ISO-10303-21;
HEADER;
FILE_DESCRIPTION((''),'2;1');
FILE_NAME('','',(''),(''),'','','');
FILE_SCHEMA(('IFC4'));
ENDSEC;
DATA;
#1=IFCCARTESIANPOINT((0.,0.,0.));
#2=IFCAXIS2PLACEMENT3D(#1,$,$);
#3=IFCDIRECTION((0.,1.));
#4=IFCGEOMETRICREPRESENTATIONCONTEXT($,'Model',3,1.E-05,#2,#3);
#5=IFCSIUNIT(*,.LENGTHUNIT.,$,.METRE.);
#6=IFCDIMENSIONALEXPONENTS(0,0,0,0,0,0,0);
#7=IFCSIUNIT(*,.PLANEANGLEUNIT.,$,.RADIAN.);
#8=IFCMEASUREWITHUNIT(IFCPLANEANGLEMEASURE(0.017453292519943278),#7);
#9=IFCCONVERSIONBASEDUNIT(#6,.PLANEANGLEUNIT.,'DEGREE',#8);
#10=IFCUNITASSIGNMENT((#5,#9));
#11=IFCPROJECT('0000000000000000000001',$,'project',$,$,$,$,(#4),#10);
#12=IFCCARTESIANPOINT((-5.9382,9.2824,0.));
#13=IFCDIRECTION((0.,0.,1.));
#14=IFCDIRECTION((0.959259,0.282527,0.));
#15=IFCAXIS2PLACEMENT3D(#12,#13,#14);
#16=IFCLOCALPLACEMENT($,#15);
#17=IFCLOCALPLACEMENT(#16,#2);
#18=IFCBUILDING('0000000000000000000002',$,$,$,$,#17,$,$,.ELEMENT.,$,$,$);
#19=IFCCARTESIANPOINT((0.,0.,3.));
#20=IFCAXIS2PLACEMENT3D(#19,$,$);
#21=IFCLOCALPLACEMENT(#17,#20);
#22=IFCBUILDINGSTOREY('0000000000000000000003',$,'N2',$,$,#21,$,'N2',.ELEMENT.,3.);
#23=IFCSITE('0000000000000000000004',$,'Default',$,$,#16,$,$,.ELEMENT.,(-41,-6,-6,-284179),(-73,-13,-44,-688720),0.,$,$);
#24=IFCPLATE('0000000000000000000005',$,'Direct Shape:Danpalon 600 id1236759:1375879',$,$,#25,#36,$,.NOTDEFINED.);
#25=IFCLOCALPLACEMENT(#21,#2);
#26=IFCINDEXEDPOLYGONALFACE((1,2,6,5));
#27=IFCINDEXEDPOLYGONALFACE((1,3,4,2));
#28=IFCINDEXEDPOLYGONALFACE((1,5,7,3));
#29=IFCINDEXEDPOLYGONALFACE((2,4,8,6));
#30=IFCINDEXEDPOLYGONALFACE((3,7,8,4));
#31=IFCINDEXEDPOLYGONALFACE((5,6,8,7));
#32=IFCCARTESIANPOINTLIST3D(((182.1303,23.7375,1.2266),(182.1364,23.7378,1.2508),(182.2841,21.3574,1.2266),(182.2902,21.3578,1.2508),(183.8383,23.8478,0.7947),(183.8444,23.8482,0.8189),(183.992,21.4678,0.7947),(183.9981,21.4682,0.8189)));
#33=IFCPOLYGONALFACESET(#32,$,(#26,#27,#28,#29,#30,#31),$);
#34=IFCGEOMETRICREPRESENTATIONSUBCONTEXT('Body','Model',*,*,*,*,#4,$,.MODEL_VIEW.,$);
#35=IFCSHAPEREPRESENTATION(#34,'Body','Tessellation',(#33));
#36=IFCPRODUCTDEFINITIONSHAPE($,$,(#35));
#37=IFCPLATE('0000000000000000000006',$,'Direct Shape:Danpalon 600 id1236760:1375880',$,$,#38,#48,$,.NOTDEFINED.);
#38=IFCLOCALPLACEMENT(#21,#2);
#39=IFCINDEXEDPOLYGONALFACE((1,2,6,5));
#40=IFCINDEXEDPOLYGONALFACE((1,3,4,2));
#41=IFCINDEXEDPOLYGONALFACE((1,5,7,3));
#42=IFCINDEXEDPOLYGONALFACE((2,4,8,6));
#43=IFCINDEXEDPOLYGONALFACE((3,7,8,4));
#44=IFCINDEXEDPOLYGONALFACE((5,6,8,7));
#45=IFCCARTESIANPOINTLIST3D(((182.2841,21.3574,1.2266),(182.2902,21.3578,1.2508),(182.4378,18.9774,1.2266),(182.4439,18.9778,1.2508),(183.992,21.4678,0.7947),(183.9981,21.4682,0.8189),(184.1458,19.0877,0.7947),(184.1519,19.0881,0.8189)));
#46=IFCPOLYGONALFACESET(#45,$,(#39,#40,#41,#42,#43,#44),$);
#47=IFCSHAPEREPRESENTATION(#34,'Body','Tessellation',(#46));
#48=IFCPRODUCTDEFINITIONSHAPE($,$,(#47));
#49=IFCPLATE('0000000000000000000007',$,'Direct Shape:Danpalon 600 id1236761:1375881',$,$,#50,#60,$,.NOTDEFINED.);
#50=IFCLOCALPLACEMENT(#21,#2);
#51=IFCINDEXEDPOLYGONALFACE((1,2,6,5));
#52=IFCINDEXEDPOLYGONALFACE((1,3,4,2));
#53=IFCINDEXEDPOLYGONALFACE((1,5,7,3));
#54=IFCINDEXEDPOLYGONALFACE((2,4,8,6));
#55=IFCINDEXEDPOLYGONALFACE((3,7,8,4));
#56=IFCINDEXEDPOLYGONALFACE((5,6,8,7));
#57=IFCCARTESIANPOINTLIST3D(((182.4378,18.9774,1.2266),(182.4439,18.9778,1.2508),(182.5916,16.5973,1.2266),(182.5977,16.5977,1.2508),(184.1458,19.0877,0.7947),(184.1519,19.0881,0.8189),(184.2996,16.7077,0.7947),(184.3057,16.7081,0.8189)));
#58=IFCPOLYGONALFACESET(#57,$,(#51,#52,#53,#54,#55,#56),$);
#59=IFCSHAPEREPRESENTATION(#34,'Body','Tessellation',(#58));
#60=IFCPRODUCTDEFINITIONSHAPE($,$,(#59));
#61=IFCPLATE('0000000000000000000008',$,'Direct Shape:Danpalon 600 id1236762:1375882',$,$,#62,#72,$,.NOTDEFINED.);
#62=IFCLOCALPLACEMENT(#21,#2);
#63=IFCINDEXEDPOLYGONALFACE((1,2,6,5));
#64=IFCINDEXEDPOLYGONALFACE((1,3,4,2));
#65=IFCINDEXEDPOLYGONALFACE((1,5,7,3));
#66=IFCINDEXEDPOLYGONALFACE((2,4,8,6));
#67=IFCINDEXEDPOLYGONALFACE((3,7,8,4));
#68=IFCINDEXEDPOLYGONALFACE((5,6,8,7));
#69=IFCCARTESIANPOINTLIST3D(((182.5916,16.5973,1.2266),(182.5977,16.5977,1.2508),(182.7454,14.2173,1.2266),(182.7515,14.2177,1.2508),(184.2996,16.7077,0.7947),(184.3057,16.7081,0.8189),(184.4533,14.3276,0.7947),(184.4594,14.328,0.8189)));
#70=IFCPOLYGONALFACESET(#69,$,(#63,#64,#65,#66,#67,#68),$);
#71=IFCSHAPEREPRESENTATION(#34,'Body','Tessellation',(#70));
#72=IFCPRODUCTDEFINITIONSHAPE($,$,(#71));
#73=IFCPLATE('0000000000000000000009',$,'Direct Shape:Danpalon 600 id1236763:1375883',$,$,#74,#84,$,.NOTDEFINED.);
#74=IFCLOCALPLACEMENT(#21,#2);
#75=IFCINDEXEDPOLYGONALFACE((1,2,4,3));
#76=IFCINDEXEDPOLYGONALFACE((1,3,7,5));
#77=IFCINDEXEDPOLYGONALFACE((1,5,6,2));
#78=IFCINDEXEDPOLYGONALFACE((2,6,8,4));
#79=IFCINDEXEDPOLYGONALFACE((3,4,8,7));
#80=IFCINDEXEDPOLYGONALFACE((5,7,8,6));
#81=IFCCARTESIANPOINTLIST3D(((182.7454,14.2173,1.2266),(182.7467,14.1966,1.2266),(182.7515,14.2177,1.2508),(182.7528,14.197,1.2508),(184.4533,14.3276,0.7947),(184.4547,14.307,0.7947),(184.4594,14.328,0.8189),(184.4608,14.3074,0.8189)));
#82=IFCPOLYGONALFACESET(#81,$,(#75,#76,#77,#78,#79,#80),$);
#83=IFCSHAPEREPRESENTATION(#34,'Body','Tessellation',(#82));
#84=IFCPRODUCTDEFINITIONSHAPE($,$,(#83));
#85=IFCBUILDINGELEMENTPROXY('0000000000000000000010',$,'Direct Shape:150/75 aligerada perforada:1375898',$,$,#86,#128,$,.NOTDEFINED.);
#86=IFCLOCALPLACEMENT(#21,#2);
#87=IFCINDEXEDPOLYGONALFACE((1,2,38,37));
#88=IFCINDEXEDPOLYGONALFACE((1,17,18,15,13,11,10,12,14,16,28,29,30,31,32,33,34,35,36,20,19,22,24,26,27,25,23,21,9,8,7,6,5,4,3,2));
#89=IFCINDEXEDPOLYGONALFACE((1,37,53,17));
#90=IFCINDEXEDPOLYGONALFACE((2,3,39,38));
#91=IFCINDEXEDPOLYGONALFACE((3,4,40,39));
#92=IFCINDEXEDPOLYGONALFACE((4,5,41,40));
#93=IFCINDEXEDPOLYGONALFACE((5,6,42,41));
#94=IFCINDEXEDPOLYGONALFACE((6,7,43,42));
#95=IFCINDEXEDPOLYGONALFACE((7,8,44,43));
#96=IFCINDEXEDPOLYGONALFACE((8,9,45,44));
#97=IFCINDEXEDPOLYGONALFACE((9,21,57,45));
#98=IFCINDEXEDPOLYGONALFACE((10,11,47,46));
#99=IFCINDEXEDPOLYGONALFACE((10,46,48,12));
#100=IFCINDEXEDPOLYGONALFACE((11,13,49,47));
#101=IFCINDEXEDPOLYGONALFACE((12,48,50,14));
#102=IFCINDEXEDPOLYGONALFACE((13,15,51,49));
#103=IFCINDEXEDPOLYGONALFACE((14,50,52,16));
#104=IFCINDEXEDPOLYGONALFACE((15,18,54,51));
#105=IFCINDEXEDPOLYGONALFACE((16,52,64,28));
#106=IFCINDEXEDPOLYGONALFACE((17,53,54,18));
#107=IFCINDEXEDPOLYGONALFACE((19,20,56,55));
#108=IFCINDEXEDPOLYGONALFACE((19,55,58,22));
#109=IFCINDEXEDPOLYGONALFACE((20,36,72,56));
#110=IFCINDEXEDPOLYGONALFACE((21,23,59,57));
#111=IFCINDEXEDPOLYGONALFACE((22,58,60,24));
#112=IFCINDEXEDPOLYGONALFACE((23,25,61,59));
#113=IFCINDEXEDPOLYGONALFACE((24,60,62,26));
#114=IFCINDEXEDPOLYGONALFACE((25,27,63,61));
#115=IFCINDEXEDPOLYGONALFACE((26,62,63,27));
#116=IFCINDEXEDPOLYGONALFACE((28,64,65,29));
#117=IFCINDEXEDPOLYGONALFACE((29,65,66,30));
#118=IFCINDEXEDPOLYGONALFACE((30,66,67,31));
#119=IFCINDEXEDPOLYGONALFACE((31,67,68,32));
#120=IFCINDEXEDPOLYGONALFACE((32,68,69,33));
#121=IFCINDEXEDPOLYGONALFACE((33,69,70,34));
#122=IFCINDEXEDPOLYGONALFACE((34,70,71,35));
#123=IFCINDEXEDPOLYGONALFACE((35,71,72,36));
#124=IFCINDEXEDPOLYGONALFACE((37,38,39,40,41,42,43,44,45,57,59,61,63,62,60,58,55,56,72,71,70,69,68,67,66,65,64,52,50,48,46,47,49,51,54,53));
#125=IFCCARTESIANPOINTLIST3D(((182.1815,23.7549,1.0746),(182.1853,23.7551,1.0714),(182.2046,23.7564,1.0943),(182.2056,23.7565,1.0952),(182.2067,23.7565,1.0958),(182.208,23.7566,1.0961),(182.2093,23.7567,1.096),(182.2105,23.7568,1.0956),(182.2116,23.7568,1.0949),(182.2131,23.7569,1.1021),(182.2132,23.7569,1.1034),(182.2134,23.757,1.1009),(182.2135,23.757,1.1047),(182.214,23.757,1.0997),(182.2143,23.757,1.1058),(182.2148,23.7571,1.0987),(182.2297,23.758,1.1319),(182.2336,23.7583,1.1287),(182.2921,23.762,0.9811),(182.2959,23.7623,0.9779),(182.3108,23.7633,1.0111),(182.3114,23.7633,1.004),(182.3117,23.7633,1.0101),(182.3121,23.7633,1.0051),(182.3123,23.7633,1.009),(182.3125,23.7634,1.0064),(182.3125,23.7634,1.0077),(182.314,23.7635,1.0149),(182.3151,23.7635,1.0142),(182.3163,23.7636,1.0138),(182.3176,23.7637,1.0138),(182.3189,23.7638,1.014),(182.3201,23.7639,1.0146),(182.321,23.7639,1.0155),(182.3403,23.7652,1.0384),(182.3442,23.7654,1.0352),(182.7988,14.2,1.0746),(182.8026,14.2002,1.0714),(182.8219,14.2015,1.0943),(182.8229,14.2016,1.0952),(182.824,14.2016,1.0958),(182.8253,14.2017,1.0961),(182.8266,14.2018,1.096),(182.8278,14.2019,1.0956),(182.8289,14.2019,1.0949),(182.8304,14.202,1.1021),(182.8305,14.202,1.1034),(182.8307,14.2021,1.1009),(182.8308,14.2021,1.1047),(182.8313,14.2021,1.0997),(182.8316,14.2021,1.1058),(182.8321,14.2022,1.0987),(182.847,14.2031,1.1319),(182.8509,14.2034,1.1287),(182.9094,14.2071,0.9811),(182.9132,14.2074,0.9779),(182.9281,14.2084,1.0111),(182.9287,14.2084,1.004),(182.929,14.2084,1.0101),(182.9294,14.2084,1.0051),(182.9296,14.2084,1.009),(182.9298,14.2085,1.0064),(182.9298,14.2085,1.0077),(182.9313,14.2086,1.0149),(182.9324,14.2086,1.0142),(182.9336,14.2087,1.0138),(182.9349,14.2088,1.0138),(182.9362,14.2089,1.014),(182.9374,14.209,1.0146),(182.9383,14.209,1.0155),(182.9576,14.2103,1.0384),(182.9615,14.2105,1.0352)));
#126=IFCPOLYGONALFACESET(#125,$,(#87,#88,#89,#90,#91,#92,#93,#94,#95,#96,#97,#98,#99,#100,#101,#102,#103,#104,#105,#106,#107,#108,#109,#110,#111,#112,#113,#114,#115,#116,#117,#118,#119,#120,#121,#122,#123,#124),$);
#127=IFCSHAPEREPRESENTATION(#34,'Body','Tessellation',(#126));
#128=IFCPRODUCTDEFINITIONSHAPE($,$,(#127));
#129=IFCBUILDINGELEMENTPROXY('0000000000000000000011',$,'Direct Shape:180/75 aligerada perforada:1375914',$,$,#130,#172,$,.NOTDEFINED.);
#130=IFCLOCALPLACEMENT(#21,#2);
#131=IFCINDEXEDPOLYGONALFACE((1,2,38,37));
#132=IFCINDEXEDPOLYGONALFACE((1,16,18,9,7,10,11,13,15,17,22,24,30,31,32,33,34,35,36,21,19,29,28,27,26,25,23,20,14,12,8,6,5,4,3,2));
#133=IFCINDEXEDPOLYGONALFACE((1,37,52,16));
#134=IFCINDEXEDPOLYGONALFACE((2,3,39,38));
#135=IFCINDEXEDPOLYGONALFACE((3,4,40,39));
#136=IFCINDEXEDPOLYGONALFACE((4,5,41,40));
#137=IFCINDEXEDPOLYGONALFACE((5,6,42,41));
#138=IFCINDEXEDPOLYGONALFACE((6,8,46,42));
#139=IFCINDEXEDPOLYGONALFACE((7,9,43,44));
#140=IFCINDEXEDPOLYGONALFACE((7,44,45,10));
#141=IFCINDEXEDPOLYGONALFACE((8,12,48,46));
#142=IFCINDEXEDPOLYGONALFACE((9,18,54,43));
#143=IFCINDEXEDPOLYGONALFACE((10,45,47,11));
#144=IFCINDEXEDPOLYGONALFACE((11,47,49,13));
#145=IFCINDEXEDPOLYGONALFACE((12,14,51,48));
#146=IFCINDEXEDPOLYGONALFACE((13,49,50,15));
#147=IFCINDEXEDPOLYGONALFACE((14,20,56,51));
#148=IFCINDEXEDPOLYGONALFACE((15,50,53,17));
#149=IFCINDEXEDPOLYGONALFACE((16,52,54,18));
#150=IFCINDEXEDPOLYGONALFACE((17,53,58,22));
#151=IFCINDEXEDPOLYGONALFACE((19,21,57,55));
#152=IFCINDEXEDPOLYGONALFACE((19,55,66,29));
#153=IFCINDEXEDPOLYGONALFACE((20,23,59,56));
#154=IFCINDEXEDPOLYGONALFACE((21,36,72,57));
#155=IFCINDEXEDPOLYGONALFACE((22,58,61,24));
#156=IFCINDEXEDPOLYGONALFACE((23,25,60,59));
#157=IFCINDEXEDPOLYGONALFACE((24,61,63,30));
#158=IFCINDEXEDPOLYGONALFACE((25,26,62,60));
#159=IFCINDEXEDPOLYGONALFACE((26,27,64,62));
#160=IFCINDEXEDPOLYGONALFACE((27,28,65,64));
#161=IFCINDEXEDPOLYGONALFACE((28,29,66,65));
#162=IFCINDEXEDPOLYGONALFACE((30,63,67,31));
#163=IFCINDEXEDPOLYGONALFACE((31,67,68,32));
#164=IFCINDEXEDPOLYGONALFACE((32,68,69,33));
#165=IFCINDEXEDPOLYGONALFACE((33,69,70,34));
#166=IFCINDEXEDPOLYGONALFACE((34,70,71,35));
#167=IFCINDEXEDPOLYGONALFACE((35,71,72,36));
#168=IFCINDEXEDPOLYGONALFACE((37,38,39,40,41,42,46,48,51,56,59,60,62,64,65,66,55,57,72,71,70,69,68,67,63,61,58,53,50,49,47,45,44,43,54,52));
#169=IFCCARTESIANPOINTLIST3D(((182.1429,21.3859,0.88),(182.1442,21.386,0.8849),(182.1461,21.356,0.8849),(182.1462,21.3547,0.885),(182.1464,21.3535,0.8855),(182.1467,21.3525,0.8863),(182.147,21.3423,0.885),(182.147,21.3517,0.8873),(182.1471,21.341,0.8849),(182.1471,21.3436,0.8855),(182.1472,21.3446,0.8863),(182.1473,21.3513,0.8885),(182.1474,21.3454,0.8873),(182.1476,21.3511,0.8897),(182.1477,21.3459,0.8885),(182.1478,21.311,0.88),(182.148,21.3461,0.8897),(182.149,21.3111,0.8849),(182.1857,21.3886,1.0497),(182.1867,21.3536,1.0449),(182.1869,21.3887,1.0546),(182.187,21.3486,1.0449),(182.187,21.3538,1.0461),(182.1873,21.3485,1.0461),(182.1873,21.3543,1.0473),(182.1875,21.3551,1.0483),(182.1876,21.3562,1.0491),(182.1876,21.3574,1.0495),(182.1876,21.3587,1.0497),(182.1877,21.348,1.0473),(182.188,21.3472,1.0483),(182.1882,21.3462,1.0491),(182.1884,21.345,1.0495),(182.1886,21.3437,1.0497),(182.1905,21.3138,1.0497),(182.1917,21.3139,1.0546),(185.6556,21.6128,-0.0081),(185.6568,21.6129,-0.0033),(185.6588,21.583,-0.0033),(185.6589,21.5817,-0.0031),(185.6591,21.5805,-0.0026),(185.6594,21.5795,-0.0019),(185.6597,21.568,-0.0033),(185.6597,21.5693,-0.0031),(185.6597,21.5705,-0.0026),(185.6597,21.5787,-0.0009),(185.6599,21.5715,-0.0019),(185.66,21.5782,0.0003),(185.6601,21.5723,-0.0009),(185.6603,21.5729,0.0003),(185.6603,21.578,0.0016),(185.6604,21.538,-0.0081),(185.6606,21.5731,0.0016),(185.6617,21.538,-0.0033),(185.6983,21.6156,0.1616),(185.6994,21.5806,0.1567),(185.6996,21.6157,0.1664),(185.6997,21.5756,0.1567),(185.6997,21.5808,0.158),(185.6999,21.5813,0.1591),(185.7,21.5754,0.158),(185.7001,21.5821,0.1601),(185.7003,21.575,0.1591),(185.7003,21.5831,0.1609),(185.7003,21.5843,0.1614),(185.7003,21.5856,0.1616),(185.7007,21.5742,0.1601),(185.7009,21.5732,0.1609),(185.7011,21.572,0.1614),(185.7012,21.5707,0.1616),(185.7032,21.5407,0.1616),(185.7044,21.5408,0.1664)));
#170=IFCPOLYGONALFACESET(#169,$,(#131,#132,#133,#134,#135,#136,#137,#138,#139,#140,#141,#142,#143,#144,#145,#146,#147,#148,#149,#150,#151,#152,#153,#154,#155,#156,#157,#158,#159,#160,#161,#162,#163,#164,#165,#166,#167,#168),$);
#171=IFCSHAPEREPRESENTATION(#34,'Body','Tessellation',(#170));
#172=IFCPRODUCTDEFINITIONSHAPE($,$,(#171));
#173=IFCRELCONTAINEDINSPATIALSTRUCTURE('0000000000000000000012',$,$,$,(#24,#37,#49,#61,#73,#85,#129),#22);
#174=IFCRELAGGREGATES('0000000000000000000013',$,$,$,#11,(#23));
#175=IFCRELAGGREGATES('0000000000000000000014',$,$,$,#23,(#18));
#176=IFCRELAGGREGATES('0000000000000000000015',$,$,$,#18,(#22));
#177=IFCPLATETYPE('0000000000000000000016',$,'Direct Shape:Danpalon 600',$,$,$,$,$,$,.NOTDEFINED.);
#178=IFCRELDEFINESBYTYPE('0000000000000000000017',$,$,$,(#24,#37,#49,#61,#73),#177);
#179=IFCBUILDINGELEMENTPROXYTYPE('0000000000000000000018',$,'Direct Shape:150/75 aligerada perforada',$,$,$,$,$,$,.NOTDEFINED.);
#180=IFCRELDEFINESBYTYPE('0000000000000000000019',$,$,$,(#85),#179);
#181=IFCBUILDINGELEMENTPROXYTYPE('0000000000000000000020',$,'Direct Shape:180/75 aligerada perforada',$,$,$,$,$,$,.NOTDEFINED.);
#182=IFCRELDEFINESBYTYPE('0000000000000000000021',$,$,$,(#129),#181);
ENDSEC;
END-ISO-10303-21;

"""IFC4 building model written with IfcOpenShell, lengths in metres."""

from ifc_helpers import new_model, entity, si_unit, converted_unit, direction, frame, frame_2d, origin, origin_2d_with_axis, place, context, subcontext, project, spatial, polyline, circle_curve, parameter, trimmed, segment, composite_curve, rectangle, outline, extrude, type_object, element, save


model = new_model("IFC4")

# Units and contexts
model_context = context("Model", 3, precision=1e-05, world=origin(), true_north=direction((0.0, 1.0)))
body_context = subcontext(model_context, "Body", "Model", "MODEL_VIEW")
ifc_project = project(units=[si_unit("LENGTHUNIT", "METRE"), converted_unit("PLANEANGLEUNIT", "DEGREE", entity("IfcPlaneAngleMeasure", 0.017453292519943278), si_unit("PLANEANGLEUNIT", "RADIAN"), dimensions=[0, 0, 0, 0, 0, 0, 0])], contexts=[model_context])

# Site, building, storey
site_placement = place(None, frame((-5.9382, 9.2824, 0.0), z_axis=(0.0, 0.0, 1.0), x_axis=(0.959259, 0.282527, 0.0)))
site = spatial("IfcSite", under=ifc_project, at=site_placement, Name="Default", CompositionType="ELEMENT", RefLatitude=(-41, -6, -6, -284179), RefLongitude=(-73, -13, -44, -688720), RefElevation=0.0)
building_placement = place(site_placement, origin())
building = spatial("IfcBuilding", under=site, at=building_placement, CompositionType="ELEMENT")
storey_placement = place(building_placement, frame((0.0, 0.0, 3.0)))
storey = spatial("IfcBuildingStorey", under=building, at=storey_placement, Name="N2", LongName="N2", CompositionType="ELEMENT", Elevation=3.0)

# Plates
plate_type = type_object("IfcPlateType", Name="Direct Shape:Danpalon 600", PredefinedType="NOTDEFINED")
plate_1_placement = place(storey_placement, origin())
element("IfcPlate", 1, at=plate_1_placement, inside=storey, type_object=plate_type, Name="Direct Shape:Danpalon 600 id1236759:1375879", PredefinedType="NOTDEFINED", context=body_context, shape_type="SweptSolid", body=[
    extrude(rectangle(XDim=0.025, YDim=1.7652, at=frame_2d((0.0, 0.0), x_axis=(1.0, 0.0))), frame((183.1411, 21.4128, 1.0228), z_axis=(-0.064471, 0.99792, 0.0), x_axis=(0.24414, 0.015773, 0.969612)), (0.0, 0.0, 1.0), 2.385),
])
plate_2_placement = place(storey_placement, origin())
element("IfcPlate", 2, at=plate_2_placement, inside=storey, type_object=plate_type, Name="Direct Shape:Danpalon 600 id1236760:1375880", PredefinedType="NOTDEFINED", context=body_context, shape_type="SweptSolid", body=[
    extrude(rectangle(XDim=0.025, YDim=1.7652, at=frame_2d((0.0, 0.0), x_axis=(1.0, 0.0))), frame((183.2949, 19.0327, 1.0228), z_axis=(-0.064471, 0.99792, 0.0), x_axis=(0.24414, 0.015773, 0.969612)), (0.0, 0.0, 1.0), 2.385),
])
plate_3_placement = place(storey_placement, origin())
element("IfcPlate", 3, at=plate_3_placement, inside=storey, type_object=plate_type, Name="Direct Shape:Danpalon 600 id1236761:1375881", PredefinedType="NOTDEFINED", context=body_context, shape_type="SweptSolid", body=[
    extrude(rectangle(XDim=0.025, YDim=1.7652, at=frame_2d((0.0, 0.0), x_axis=(1.0, 0.0))), frame((183.4486, 16.6527, 1.0228), z_axis=(-0.064471, 0.99792, 0.0), x_axis=(0.24414, 0.015773, 0.969612)), (0.0, 0.0, 1.0), 2.385),
])
plate_4_placement = place(storey_placement, origin())
element("IfcPlate", 4, at=plate_4_placement, inside=storey, type_object=plate_type, Name="Direct Shape:Danpalon 600 id1236762:1375882", PredefinedType="NOTDEFINED", context=body_context, shape_type="SweptSolid", body=[
    extrude(rectangle(XDim=0.025, YDim=1.7652, at=origin_2d_with_axis()), frame((183.6024, 14.2727, 1.0228), z_axis=(-0.064471, 0.99792, 0.0), x_axis=(0.24414, 0.015773, 0.969612)), (0.0, 0.0, 1.0), 2.385),
])
plate_5_placement = place(storey_placement, origin())
element("IfcPlate", 5, at=plate_5_placement, inside=storey, type_object=plate_type, Name="Direct Shape:Danpalon 600 id1236763:1375883", PredefinedType="NOTDEFINED", context=body_context, shape_type="SweptSolid", body=[
    extrude(rectangle(XDim=0.025, YDim=0.0207, at=frame_2d((0.0, 0.0), x_axis=(0.0, 1.0))), frame((182.7491, 14.2072, 1.2387), z_axis=(0.967595, 0.062512, -0.244649), x_axis=(-0.064471, 0.99792, 0.0)), (0.0, 0.0, 1.0), 1.7652),
])

# Building element proxies
building_element_proxy_type_1 = type_object("IfcBuildingElementProxyType", Name="Direct Shape:150/75 aligerada perforada", PredefinedType="NOTDEFINED")
proxy_1_placement = place(storey_placement, origin())
element("IfcBuildingElementProxy", 6, at=proxy_1_placement, inside=storey, type_object=building_element_proxy_type_1, Name="Direct Shape:150/75 aligerada perforada:1375898", PredefinedType="NOTDEFINED", context=body_context, shape_type="SweptSolid", body=[
    extrude(outline(composite_curve([segment(polyline([(-0.0375, -0.07), (-0.0375, -0.075)]), True, "CONTINUOUS"), segment(polyline([(-0.0375, -0.075), (0.0375, -0.075)]), True, "CONTINUOUS"), segment(polyline([(0.0375, -0.075), (0.0375, -0.07)]), True, "CONTINUOUS"), segment(polyline([(0.0375, -0.07), (0.0075, -0.07)]), True, "CONTINUOUS"), segment(trimmed(circle_curve(frame_2d((0.0075, -0.065), x_axis=(1.0, 0.0)), 0.005), [parameter(180.0)], [parameter(270.0)], True, "PARAMETER"), False, "CONTINUOUS"), segment(polyline([(0.0025, -0.065), (0.0025, 0.065)]), True, "CONTINUOUS"), segment(trimmed(circle_curve(frame_2d((0.0075, 0.065), x_axis=(1.0, 0.0)), 0.005), [parameter(90.0)], [parameter(180.0)], True, "PARAMETER"), False, "CONTINUOUS"), segment(polyline([(0.0075, 0.07), (0.0375, 0.07)]), True, "CONTINUOUS"), segment(polyline([(0.0375, 0.07), (0.0375, 0.075)]), True, "CONTINUOUS"), segment(polyline([(0.0375, 0.075), (-0.0375, 0.075)]), True, "CONTINUOUS"), segment(polyline([(-0.0375, 0.075), (-0.0375, 0.07)]), True, "CONTINUOUS"), segment(polyline([(-0.0375, 0.07), (-0.0075, 0.07)]), True, "CONTINUOUS"), segment(trimmed(circle_curve(frame_2d((-0.0075, 0.065), x_axis=(1.0, 0.0)), 0.005), [parameter(360.0)], [parameter(90.0)], True, "PARAMETER"), False, "CONTINUOUS"), segment(polyline([(-0.0025, 0.065), (-0.0025, -0.065)]), True, "CONTINUOUS"), segment(trimmed(circle_curve(frame_2d((-0.0075, -0.065), x_axis=(1.0, 0.0)), 0.005), [parameter(270.0)], [parameter(0.0)], True, "PARAMETER"), False, "CONTINUOUS"), segment(polyline([(-0.0075, -0.07), (-0.0375, -0.07)]), True, "CONTINUOUS")], self_intersect=False)), frame((182.8801, 14.2053, 1.0549), z_axis=(0.064471, -0.99792, 0.0), x_axis=(0.643449, 0.041571, 0.764359)), (0.0, 0.0, -1.0), 9.5748),
])
building_element_proxy_type_2 = type_object("IfcBuildingElementProxyType", Name="Direct Shape:180/75 aligerada perforada", PredefinedType="NOTDEFINED")
proxy_2_placement = place(storey_placement, origin())
element("IfcBuildingElementProxy", 7, at=proxy_2_placement, inside=storey, type_object=building_element_proxy_type_2, Name="Direct Shape:180/75 aligerada perforada:1375914", PredefinedType="NOTDEFINED", context=body_context, shape_type="SweptSolid", body=[
    extrude(outline(composite_curve([segment(polyline([(-0.0375, -0.085), (-0.0375, -0.09)]), True, "CONTINUOUS"), segment(polyline([(-0.0375, -0.09), (0.0375, -0.09)]), True, "CONTINUOUS"), segment(polyline([(0.0375, -0.09), (0.0375, -0.085)]), True, "CONTINUOUS"), segment(polyline([(0.0375, -0.085), (0.0075, -0.085)]), True, "CONTINUOUS"), segment(trimmed(circle_curve(frame_2d((0.0075, -0.08), x_axis=(1.0, 0.0)), 0.005), [parameter(180.0)], [parameter(270.0)], True, "PARAMETER"), False, "CONTINUOUS"), segment(polyline([(0.0025, -0.08), (0.0025, 0.08)]), True, "CONTINUOUS"), segment(trimmed(circle_curve(frame_2d((0.0075, 0.08), x_axis=(1.0, 0.0)), 0.005), [parameter(90.0)], [parameter(180.0)], True, "PARAMETER"), False, "CONTINUOUS"), segment(polyline([(0.0075, 0.085), (0.0375, 0.085)]), True, "CONTINUOUS"), segment(polyline([(0.0375, 0.085), (0.0375, 0.09)]), True, "CONTINUOUS"), segment(polyline([(0.0375, 0.09), (-0.0375, 0.09)]), True, "CONTINUOUS"), segment(polyline([(-0.0375, 0.09), (-0.0375, 0.085)]), True, "CONTINUOUS"), segment(polyline([(-0.0375, 0.085), (-0.0075, 0.085)]), True, "CONTINUOUS"), segment(trimmed(circle_curve(frame_2d((-0.0075, 0.08), x_axis=(1.0, 0.0)), 0.005), [parameter(360.0)], [parameter(90.0)], True, "PARAMETER"), False, "CONTINUOUS"), segment(polyline([(-0.0025, 0.08), (-0.0025, -0.08)]), True, "CONTINUOUS"), segment(trimmed(circle_curve(frame_2d((-0.0075, -0.08), x_axis=(1.0, 0.0)), 0.005), [parameter(270.0)], [parameter(0.0)], True, "PARAMETER"), False, "CONTINUOUS"), segment(polyline([(-0.0075, -0.085), (-0.0375, -0.085)]), True, "CONTINUOUS")], self_intersect=False)), frame((182.1673, 21.3499, 0.9673), z_axis=(-0.967595, -0.062512, 0.244649), x_axis=(0.064471, -0.99792, 0.0)), (0.0, 0.0, -1.0), 3.6303),
])

save(model, "model.ifc")
